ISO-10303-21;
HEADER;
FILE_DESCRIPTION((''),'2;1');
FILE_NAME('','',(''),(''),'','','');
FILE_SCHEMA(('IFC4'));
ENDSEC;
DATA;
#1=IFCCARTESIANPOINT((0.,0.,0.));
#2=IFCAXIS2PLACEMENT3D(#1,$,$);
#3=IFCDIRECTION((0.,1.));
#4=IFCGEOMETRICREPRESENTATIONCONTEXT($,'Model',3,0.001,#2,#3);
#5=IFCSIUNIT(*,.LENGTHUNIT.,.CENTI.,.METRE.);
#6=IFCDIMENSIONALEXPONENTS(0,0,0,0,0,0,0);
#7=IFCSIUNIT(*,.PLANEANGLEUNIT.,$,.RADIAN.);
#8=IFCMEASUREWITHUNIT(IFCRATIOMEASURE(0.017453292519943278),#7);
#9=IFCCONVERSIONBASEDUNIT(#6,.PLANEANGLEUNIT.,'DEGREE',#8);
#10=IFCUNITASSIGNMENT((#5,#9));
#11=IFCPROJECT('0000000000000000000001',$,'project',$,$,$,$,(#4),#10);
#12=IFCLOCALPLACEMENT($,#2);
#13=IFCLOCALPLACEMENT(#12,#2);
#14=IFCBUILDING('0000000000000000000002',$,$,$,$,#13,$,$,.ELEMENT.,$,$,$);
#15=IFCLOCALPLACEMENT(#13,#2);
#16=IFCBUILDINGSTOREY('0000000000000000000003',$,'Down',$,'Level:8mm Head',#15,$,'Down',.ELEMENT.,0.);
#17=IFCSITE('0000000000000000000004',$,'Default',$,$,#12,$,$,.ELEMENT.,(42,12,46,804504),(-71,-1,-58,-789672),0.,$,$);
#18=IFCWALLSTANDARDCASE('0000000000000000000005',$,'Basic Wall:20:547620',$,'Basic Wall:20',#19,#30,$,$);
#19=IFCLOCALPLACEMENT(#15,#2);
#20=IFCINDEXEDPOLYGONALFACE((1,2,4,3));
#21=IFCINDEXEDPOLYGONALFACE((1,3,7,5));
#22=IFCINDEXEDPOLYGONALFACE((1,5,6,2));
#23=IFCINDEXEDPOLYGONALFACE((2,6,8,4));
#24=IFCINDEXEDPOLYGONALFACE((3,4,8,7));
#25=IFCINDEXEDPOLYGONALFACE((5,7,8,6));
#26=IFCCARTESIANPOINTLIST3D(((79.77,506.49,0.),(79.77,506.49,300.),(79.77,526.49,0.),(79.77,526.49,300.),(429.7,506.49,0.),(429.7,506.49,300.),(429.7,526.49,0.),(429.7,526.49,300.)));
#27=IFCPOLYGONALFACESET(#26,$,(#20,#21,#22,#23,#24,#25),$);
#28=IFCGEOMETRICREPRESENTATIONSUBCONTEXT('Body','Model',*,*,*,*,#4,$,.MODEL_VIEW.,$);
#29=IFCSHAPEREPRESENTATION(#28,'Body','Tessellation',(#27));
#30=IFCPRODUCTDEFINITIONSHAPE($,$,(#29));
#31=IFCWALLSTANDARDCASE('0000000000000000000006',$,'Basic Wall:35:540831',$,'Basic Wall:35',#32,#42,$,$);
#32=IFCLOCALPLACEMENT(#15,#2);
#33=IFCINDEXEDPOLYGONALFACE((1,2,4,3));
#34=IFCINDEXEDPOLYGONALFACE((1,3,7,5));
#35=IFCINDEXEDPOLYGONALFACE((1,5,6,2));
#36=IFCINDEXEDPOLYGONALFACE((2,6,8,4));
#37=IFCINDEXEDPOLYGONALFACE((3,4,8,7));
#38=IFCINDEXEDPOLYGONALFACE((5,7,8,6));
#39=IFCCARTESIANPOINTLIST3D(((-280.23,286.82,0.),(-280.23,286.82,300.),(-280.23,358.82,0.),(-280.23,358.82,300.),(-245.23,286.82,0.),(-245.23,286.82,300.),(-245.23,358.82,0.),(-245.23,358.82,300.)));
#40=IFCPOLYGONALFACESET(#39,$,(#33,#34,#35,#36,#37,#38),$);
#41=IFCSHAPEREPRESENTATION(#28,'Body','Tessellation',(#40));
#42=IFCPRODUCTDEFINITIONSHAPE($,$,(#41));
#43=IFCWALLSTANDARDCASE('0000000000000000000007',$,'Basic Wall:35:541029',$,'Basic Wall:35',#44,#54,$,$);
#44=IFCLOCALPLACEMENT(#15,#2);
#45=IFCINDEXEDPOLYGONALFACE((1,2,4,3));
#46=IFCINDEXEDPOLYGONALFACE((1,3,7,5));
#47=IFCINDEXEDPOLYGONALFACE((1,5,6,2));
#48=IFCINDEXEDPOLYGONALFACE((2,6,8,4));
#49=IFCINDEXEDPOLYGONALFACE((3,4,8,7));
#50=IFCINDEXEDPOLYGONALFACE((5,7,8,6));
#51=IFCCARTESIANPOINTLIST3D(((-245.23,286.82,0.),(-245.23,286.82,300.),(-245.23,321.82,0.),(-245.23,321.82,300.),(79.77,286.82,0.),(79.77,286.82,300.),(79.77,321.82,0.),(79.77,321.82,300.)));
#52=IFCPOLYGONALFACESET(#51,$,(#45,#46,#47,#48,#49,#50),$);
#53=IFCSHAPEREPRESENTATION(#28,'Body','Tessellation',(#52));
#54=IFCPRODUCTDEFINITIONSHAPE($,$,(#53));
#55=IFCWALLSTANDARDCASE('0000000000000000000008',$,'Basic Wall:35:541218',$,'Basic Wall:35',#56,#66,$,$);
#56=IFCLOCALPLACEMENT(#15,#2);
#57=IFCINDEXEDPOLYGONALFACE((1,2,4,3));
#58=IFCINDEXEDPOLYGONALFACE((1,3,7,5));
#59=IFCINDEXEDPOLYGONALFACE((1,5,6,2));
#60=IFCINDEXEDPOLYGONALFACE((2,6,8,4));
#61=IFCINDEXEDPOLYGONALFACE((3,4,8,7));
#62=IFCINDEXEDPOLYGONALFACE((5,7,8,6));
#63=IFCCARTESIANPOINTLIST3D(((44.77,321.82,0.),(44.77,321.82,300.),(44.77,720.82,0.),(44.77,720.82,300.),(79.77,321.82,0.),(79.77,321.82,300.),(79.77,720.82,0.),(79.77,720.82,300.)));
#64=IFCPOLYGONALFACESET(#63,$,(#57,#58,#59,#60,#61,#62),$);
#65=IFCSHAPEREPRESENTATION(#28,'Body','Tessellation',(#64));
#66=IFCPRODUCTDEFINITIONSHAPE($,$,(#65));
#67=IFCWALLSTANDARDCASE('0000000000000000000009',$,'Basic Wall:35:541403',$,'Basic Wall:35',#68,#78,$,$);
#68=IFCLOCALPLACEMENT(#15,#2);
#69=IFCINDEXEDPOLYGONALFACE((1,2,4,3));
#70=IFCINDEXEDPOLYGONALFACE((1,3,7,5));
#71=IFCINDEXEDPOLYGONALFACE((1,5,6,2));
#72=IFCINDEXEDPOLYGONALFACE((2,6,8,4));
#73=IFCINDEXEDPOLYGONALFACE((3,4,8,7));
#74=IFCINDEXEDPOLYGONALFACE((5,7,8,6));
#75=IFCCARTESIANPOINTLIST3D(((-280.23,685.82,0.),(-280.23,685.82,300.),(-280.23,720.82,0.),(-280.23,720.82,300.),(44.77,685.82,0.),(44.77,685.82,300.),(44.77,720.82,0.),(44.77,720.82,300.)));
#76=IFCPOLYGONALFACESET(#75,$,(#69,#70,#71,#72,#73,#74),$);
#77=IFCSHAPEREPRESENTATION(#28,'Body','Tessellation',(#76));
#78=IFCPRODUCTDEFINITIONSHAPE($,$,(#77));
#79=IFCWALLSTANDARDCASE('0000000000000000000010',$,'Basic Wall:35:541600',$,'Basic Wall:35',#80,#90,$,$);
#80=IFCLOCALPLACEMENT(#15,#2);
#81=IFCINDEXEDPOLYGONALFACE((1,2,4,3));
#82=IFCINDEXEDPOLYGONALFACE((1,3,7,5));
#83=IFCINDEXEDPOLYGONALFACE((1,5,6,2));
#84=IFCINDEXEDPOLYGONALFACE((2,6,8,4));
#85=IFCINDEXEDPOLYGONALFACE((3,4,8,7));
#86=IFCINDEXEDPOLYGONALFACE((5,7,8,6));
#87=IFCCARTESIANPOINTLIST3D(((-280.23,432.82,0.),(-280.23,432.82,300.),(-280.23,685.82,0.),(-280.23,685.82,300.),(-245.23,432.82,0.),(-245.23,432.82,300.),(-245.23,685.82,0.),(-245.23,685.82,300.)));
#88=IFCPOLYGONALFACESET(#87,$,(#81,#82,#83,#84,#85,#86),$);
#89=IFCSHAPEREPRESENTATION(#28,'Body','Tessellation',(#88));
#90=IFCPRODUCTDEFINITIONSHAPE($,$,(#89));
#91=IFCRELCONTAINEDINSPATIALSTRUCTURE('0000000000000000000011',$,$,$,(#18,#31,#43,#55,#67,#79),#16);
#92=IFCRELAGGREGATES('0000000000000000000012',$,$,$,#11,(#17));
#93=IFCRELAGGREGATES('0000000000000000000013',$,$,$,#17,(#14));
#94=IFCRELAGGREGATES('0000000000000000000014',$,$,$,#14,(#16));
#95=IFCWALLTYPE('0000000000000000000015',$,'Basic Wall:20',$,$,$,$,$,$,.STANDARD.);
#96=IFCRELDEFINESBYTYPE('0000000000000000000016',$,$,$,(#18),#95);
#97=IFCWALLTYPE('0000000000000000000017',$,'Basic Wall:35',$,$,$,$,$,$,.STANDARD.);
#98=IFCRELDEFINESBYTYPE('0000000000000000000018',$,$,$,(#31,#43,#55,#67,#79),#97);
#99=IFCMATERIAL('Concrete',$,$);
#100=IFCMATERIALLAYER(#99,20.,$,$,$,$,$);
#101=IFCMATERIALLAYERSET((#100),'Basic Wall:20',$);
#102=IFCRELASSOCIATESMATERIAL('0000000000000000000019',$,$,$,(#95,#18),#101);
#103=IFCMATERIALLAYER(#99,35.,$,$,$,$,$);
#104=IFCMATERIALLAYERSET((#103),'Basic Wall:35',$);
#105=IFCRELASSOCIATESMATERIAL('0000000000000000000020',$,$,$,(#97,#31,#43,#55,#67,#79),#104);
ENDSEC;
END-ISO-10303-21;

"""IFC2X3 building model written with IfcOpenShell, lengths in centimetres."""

from ifc_helpers import new_model, entity, si_unit, converted_unit, direction, frame, frame_2d, origin, place, context, subcontext, project, spatial, rectangle, extrude, material, layer, layer_set, layer_usage, type_object, element, save


model = new_model("IFC2X3")

# Units and contexts
model_context = context("Model", 3, precision=0.001, world=origin(), true_north=direction((0.0, 1.0)))
body_context = subcontext(model_context, "Body", "Model", "MODEL_VIEW")
ifc_project = project(units=[si_unit("LENGTHUNIT", "METRE", prefix="CENTI"), converted_unit("PLANEANGLEUNIT", "DEGREE", entity("IfcRatioMeasure", 0.017453292519943278), si_unit("PLANEANGLEUNIT", "RADIAN"), dimensions=[0, 0, 0, 0, 0, 0, 0])], contexts=[model_context])

# Site, building, storey
site_placement = place(None, origin())
site = spatial("IfcSite", under=ifc_project, at=site_placement, Name="Default", CompositionType="ELEMENT", RefLatitude=(42, 12, 46, 804504), RefLongitude=(-71, -1, -58, -789672), RefElevation=0.0)
building_placement = place(site_placement, origin())
building = spatial("IfcBuilding", under=site, at=building_placement, CompositionType="ELEMENT")
storey_placement = place(building_placement, origin())
storey = spatial("IfcBuildingStorey", under=building, at=storey_placement, Name="Down", ObjectType="Level:8mm Head", LongName="Down", CompositionType="ELEMENT", Elevation=0.0)

# Shared definitions
ifc_material = material(Name="Concrete")

# Walls
ifc_layer_1 = layer(ifc_material, 20.0)
ifc_layer_set_1 = layer_set([ifc_layer_1], Name="Basic Wall:20")
wall_type_1 = type_object("IfcWallType", Name="Basic Wall:20", PredefinedType="STANDARD", material=ifc_layer_set_1)
ifc_layer_usage_1 = layer_usage(ifc_layer_set_1, "AXIS2", "POSITIVE", -10.0)
wall_1_placement = place(storey_placement, frame((429.7, 516.49, 0.0), z_axis=(0.0, 0.0, 1.0), x_axis=(-1.0, 0.0, 0.0)))
element("IfcWallStandardCase", 1, at=wall_1_placement, inside=storey, type_object=wall_type_1, material=ifc_layer_usage_1, Name="Basic Wall:20:547620", ObjectType="Basic Wall:20", context=body_context, shape_type="SweptSolid", body=[
    extrude(rectangle(XDim=349.94, YDim=20.0, at=frame_2d((174.97, 0.0), x_axis=(-1.0, 0.0))), origin(), (0.0, 0.0, 1.0), 300.0),
])
ifc_layer_2 = layer(ifc_material, 35.0)
ifc_layer_set_2 = layer_set([ifc_layer_2], Name="Basic Wall:35")
ifc_layer_usage_2 = layer_usage(ifc_layer_set_2, "AXIS2", "POSITIVE", -17.5)
wall_type_2 = type_object("IfcWallType", Name="Basic Wall:35", PredefinedType="STANDARD", material=ifc_layer_set_2)
wall_2_placement = place(storey_placement, frame((-262.73, 358.82, 0.0), z_axis=(0.0, 0.0, 1.0), x_axis=(0.0, -1.0, 0.0)))
element("IfcWallStandardCase", 2, at=wall_2_placement, inside=storey, type_object=wall_type_2, material=ifc_layer_usage_2, Name="Basic Wall:35:540831", ObjectType="Basic Wall:35", context=body_context, shape_type="SweptSolid", body=[
    extrude(rectangle(XDim=72.0, YDim=35.0, at=frame_2d((36.0, 0.0), x_axis=(-1.0, 0.0))), origin(), (0.0, 0.0, 1.0), 300.0),
])
ifc_layer_usage_3 = layer_usage(ifc_layer_set_2, "AXIS2", "POSITIVE", -17.5)
wall_3_placement = place(storey_placement, frame((-245.23, 304.32, 0.0)))
element("IfcWallStandardCase", 3, at=wall_3_placement, inside=storey, type_object=wall_type_2, material=ifc_layer_usage_3, Name="Basic Wall:35:541029", ObjectType="Basic Wall:35", context=body_context, shape_type="SweptSolid", body=[
    extrude(rectangle(XDim=325.0, YDim=35.0, at=frame_2d((162.5, 0.0), x_axis=(-1.0, 0.0))), origin(), (0.0, 0.0, 1.0), 300.0),
])
ifc_layer_usage_4 = layer_usage(ifc_layer_set_2, "AXIS2", "POSITIVE", -17.5)
wall_4_placement = place(storey_placement, frame((62.27, 321.82, 0.0), z_axis=(0.0, 0.0, 1.0), x_axis=(0.0, 1.0, 0.0)))
element("IfcWallStandardCase", 4, at=wall_4_placement, inside=storey, type_object=wall_type_2, material=ifc_layer_usage_4, Name="Basic Wall:35:541218", ObjectType="Basic Wall:35", context=body_context, shape_type="SweptSolid", body=[
    extrude(rectangle(XDim=399.0, YDim=35.0, at=frame_2d((199.5, 0.0), x_axis=(-1.0, 0.0))), origin(), (0.0, 0.0, 1.0), 300.0),
])
ifc_layer_usage_5 = layer_usage(ifc_layer_set_2, "AXIS2", "POSITIVE", -17.5)
wall_5_placement = place(storey_placement, frame((44.77, 703.32, 0.0), z_axis=(0.0, 0.0, 1.0), x_axis=(-1.0, 0.0, 0.0)))
element("IfcWallStandardCase", 5, at=wall_5_placement, inside=storey, type_object=wall_type_2, material=ifc_layer_usage_5, Name="Basic Wall:35:541403", ObjectType="Basic Wall:35", context=body_context, shape_type="SweptSolid", body=[
    extrude(rectangle(XDim=325.0, YDim=35.0, at=frame_2d((162.5, 0.0), x_axis=(-1.0, 0.0))), origin(), (0.0, 0.0, 1.0), 300.0),
])
ifc_layer_usage_6 = layer_usage(ifc_layer_set_2, "AXIS2", "POSITIVE", -17.5)
wall_6_placement = place(storey_placement, frame((-262.73, 685.82, 0.0), z_axis=(0.0, 0.0, 1.0), x_axis=(0.0, -1.0, 0.0)))
element("IfcWallStandardCase", 6, at=wall_6_placement, inside=storey, type_object=wall_type_2, material=ifc_layer_usage_6, Name="Basic Wall:35:541600", ObjectType="Basic Wall:35", context=body_context, shape_type="SweptSolid", body=[
    extrude(rectangle(XDim=253.0, YDim=35.0, at=frame_2d((126.5, 0.0), x_axis=(-1.0, 0.0))), origin(), (0.0, 0.0, 1.0), 300.0),
])

save(model, "model.ifc")
